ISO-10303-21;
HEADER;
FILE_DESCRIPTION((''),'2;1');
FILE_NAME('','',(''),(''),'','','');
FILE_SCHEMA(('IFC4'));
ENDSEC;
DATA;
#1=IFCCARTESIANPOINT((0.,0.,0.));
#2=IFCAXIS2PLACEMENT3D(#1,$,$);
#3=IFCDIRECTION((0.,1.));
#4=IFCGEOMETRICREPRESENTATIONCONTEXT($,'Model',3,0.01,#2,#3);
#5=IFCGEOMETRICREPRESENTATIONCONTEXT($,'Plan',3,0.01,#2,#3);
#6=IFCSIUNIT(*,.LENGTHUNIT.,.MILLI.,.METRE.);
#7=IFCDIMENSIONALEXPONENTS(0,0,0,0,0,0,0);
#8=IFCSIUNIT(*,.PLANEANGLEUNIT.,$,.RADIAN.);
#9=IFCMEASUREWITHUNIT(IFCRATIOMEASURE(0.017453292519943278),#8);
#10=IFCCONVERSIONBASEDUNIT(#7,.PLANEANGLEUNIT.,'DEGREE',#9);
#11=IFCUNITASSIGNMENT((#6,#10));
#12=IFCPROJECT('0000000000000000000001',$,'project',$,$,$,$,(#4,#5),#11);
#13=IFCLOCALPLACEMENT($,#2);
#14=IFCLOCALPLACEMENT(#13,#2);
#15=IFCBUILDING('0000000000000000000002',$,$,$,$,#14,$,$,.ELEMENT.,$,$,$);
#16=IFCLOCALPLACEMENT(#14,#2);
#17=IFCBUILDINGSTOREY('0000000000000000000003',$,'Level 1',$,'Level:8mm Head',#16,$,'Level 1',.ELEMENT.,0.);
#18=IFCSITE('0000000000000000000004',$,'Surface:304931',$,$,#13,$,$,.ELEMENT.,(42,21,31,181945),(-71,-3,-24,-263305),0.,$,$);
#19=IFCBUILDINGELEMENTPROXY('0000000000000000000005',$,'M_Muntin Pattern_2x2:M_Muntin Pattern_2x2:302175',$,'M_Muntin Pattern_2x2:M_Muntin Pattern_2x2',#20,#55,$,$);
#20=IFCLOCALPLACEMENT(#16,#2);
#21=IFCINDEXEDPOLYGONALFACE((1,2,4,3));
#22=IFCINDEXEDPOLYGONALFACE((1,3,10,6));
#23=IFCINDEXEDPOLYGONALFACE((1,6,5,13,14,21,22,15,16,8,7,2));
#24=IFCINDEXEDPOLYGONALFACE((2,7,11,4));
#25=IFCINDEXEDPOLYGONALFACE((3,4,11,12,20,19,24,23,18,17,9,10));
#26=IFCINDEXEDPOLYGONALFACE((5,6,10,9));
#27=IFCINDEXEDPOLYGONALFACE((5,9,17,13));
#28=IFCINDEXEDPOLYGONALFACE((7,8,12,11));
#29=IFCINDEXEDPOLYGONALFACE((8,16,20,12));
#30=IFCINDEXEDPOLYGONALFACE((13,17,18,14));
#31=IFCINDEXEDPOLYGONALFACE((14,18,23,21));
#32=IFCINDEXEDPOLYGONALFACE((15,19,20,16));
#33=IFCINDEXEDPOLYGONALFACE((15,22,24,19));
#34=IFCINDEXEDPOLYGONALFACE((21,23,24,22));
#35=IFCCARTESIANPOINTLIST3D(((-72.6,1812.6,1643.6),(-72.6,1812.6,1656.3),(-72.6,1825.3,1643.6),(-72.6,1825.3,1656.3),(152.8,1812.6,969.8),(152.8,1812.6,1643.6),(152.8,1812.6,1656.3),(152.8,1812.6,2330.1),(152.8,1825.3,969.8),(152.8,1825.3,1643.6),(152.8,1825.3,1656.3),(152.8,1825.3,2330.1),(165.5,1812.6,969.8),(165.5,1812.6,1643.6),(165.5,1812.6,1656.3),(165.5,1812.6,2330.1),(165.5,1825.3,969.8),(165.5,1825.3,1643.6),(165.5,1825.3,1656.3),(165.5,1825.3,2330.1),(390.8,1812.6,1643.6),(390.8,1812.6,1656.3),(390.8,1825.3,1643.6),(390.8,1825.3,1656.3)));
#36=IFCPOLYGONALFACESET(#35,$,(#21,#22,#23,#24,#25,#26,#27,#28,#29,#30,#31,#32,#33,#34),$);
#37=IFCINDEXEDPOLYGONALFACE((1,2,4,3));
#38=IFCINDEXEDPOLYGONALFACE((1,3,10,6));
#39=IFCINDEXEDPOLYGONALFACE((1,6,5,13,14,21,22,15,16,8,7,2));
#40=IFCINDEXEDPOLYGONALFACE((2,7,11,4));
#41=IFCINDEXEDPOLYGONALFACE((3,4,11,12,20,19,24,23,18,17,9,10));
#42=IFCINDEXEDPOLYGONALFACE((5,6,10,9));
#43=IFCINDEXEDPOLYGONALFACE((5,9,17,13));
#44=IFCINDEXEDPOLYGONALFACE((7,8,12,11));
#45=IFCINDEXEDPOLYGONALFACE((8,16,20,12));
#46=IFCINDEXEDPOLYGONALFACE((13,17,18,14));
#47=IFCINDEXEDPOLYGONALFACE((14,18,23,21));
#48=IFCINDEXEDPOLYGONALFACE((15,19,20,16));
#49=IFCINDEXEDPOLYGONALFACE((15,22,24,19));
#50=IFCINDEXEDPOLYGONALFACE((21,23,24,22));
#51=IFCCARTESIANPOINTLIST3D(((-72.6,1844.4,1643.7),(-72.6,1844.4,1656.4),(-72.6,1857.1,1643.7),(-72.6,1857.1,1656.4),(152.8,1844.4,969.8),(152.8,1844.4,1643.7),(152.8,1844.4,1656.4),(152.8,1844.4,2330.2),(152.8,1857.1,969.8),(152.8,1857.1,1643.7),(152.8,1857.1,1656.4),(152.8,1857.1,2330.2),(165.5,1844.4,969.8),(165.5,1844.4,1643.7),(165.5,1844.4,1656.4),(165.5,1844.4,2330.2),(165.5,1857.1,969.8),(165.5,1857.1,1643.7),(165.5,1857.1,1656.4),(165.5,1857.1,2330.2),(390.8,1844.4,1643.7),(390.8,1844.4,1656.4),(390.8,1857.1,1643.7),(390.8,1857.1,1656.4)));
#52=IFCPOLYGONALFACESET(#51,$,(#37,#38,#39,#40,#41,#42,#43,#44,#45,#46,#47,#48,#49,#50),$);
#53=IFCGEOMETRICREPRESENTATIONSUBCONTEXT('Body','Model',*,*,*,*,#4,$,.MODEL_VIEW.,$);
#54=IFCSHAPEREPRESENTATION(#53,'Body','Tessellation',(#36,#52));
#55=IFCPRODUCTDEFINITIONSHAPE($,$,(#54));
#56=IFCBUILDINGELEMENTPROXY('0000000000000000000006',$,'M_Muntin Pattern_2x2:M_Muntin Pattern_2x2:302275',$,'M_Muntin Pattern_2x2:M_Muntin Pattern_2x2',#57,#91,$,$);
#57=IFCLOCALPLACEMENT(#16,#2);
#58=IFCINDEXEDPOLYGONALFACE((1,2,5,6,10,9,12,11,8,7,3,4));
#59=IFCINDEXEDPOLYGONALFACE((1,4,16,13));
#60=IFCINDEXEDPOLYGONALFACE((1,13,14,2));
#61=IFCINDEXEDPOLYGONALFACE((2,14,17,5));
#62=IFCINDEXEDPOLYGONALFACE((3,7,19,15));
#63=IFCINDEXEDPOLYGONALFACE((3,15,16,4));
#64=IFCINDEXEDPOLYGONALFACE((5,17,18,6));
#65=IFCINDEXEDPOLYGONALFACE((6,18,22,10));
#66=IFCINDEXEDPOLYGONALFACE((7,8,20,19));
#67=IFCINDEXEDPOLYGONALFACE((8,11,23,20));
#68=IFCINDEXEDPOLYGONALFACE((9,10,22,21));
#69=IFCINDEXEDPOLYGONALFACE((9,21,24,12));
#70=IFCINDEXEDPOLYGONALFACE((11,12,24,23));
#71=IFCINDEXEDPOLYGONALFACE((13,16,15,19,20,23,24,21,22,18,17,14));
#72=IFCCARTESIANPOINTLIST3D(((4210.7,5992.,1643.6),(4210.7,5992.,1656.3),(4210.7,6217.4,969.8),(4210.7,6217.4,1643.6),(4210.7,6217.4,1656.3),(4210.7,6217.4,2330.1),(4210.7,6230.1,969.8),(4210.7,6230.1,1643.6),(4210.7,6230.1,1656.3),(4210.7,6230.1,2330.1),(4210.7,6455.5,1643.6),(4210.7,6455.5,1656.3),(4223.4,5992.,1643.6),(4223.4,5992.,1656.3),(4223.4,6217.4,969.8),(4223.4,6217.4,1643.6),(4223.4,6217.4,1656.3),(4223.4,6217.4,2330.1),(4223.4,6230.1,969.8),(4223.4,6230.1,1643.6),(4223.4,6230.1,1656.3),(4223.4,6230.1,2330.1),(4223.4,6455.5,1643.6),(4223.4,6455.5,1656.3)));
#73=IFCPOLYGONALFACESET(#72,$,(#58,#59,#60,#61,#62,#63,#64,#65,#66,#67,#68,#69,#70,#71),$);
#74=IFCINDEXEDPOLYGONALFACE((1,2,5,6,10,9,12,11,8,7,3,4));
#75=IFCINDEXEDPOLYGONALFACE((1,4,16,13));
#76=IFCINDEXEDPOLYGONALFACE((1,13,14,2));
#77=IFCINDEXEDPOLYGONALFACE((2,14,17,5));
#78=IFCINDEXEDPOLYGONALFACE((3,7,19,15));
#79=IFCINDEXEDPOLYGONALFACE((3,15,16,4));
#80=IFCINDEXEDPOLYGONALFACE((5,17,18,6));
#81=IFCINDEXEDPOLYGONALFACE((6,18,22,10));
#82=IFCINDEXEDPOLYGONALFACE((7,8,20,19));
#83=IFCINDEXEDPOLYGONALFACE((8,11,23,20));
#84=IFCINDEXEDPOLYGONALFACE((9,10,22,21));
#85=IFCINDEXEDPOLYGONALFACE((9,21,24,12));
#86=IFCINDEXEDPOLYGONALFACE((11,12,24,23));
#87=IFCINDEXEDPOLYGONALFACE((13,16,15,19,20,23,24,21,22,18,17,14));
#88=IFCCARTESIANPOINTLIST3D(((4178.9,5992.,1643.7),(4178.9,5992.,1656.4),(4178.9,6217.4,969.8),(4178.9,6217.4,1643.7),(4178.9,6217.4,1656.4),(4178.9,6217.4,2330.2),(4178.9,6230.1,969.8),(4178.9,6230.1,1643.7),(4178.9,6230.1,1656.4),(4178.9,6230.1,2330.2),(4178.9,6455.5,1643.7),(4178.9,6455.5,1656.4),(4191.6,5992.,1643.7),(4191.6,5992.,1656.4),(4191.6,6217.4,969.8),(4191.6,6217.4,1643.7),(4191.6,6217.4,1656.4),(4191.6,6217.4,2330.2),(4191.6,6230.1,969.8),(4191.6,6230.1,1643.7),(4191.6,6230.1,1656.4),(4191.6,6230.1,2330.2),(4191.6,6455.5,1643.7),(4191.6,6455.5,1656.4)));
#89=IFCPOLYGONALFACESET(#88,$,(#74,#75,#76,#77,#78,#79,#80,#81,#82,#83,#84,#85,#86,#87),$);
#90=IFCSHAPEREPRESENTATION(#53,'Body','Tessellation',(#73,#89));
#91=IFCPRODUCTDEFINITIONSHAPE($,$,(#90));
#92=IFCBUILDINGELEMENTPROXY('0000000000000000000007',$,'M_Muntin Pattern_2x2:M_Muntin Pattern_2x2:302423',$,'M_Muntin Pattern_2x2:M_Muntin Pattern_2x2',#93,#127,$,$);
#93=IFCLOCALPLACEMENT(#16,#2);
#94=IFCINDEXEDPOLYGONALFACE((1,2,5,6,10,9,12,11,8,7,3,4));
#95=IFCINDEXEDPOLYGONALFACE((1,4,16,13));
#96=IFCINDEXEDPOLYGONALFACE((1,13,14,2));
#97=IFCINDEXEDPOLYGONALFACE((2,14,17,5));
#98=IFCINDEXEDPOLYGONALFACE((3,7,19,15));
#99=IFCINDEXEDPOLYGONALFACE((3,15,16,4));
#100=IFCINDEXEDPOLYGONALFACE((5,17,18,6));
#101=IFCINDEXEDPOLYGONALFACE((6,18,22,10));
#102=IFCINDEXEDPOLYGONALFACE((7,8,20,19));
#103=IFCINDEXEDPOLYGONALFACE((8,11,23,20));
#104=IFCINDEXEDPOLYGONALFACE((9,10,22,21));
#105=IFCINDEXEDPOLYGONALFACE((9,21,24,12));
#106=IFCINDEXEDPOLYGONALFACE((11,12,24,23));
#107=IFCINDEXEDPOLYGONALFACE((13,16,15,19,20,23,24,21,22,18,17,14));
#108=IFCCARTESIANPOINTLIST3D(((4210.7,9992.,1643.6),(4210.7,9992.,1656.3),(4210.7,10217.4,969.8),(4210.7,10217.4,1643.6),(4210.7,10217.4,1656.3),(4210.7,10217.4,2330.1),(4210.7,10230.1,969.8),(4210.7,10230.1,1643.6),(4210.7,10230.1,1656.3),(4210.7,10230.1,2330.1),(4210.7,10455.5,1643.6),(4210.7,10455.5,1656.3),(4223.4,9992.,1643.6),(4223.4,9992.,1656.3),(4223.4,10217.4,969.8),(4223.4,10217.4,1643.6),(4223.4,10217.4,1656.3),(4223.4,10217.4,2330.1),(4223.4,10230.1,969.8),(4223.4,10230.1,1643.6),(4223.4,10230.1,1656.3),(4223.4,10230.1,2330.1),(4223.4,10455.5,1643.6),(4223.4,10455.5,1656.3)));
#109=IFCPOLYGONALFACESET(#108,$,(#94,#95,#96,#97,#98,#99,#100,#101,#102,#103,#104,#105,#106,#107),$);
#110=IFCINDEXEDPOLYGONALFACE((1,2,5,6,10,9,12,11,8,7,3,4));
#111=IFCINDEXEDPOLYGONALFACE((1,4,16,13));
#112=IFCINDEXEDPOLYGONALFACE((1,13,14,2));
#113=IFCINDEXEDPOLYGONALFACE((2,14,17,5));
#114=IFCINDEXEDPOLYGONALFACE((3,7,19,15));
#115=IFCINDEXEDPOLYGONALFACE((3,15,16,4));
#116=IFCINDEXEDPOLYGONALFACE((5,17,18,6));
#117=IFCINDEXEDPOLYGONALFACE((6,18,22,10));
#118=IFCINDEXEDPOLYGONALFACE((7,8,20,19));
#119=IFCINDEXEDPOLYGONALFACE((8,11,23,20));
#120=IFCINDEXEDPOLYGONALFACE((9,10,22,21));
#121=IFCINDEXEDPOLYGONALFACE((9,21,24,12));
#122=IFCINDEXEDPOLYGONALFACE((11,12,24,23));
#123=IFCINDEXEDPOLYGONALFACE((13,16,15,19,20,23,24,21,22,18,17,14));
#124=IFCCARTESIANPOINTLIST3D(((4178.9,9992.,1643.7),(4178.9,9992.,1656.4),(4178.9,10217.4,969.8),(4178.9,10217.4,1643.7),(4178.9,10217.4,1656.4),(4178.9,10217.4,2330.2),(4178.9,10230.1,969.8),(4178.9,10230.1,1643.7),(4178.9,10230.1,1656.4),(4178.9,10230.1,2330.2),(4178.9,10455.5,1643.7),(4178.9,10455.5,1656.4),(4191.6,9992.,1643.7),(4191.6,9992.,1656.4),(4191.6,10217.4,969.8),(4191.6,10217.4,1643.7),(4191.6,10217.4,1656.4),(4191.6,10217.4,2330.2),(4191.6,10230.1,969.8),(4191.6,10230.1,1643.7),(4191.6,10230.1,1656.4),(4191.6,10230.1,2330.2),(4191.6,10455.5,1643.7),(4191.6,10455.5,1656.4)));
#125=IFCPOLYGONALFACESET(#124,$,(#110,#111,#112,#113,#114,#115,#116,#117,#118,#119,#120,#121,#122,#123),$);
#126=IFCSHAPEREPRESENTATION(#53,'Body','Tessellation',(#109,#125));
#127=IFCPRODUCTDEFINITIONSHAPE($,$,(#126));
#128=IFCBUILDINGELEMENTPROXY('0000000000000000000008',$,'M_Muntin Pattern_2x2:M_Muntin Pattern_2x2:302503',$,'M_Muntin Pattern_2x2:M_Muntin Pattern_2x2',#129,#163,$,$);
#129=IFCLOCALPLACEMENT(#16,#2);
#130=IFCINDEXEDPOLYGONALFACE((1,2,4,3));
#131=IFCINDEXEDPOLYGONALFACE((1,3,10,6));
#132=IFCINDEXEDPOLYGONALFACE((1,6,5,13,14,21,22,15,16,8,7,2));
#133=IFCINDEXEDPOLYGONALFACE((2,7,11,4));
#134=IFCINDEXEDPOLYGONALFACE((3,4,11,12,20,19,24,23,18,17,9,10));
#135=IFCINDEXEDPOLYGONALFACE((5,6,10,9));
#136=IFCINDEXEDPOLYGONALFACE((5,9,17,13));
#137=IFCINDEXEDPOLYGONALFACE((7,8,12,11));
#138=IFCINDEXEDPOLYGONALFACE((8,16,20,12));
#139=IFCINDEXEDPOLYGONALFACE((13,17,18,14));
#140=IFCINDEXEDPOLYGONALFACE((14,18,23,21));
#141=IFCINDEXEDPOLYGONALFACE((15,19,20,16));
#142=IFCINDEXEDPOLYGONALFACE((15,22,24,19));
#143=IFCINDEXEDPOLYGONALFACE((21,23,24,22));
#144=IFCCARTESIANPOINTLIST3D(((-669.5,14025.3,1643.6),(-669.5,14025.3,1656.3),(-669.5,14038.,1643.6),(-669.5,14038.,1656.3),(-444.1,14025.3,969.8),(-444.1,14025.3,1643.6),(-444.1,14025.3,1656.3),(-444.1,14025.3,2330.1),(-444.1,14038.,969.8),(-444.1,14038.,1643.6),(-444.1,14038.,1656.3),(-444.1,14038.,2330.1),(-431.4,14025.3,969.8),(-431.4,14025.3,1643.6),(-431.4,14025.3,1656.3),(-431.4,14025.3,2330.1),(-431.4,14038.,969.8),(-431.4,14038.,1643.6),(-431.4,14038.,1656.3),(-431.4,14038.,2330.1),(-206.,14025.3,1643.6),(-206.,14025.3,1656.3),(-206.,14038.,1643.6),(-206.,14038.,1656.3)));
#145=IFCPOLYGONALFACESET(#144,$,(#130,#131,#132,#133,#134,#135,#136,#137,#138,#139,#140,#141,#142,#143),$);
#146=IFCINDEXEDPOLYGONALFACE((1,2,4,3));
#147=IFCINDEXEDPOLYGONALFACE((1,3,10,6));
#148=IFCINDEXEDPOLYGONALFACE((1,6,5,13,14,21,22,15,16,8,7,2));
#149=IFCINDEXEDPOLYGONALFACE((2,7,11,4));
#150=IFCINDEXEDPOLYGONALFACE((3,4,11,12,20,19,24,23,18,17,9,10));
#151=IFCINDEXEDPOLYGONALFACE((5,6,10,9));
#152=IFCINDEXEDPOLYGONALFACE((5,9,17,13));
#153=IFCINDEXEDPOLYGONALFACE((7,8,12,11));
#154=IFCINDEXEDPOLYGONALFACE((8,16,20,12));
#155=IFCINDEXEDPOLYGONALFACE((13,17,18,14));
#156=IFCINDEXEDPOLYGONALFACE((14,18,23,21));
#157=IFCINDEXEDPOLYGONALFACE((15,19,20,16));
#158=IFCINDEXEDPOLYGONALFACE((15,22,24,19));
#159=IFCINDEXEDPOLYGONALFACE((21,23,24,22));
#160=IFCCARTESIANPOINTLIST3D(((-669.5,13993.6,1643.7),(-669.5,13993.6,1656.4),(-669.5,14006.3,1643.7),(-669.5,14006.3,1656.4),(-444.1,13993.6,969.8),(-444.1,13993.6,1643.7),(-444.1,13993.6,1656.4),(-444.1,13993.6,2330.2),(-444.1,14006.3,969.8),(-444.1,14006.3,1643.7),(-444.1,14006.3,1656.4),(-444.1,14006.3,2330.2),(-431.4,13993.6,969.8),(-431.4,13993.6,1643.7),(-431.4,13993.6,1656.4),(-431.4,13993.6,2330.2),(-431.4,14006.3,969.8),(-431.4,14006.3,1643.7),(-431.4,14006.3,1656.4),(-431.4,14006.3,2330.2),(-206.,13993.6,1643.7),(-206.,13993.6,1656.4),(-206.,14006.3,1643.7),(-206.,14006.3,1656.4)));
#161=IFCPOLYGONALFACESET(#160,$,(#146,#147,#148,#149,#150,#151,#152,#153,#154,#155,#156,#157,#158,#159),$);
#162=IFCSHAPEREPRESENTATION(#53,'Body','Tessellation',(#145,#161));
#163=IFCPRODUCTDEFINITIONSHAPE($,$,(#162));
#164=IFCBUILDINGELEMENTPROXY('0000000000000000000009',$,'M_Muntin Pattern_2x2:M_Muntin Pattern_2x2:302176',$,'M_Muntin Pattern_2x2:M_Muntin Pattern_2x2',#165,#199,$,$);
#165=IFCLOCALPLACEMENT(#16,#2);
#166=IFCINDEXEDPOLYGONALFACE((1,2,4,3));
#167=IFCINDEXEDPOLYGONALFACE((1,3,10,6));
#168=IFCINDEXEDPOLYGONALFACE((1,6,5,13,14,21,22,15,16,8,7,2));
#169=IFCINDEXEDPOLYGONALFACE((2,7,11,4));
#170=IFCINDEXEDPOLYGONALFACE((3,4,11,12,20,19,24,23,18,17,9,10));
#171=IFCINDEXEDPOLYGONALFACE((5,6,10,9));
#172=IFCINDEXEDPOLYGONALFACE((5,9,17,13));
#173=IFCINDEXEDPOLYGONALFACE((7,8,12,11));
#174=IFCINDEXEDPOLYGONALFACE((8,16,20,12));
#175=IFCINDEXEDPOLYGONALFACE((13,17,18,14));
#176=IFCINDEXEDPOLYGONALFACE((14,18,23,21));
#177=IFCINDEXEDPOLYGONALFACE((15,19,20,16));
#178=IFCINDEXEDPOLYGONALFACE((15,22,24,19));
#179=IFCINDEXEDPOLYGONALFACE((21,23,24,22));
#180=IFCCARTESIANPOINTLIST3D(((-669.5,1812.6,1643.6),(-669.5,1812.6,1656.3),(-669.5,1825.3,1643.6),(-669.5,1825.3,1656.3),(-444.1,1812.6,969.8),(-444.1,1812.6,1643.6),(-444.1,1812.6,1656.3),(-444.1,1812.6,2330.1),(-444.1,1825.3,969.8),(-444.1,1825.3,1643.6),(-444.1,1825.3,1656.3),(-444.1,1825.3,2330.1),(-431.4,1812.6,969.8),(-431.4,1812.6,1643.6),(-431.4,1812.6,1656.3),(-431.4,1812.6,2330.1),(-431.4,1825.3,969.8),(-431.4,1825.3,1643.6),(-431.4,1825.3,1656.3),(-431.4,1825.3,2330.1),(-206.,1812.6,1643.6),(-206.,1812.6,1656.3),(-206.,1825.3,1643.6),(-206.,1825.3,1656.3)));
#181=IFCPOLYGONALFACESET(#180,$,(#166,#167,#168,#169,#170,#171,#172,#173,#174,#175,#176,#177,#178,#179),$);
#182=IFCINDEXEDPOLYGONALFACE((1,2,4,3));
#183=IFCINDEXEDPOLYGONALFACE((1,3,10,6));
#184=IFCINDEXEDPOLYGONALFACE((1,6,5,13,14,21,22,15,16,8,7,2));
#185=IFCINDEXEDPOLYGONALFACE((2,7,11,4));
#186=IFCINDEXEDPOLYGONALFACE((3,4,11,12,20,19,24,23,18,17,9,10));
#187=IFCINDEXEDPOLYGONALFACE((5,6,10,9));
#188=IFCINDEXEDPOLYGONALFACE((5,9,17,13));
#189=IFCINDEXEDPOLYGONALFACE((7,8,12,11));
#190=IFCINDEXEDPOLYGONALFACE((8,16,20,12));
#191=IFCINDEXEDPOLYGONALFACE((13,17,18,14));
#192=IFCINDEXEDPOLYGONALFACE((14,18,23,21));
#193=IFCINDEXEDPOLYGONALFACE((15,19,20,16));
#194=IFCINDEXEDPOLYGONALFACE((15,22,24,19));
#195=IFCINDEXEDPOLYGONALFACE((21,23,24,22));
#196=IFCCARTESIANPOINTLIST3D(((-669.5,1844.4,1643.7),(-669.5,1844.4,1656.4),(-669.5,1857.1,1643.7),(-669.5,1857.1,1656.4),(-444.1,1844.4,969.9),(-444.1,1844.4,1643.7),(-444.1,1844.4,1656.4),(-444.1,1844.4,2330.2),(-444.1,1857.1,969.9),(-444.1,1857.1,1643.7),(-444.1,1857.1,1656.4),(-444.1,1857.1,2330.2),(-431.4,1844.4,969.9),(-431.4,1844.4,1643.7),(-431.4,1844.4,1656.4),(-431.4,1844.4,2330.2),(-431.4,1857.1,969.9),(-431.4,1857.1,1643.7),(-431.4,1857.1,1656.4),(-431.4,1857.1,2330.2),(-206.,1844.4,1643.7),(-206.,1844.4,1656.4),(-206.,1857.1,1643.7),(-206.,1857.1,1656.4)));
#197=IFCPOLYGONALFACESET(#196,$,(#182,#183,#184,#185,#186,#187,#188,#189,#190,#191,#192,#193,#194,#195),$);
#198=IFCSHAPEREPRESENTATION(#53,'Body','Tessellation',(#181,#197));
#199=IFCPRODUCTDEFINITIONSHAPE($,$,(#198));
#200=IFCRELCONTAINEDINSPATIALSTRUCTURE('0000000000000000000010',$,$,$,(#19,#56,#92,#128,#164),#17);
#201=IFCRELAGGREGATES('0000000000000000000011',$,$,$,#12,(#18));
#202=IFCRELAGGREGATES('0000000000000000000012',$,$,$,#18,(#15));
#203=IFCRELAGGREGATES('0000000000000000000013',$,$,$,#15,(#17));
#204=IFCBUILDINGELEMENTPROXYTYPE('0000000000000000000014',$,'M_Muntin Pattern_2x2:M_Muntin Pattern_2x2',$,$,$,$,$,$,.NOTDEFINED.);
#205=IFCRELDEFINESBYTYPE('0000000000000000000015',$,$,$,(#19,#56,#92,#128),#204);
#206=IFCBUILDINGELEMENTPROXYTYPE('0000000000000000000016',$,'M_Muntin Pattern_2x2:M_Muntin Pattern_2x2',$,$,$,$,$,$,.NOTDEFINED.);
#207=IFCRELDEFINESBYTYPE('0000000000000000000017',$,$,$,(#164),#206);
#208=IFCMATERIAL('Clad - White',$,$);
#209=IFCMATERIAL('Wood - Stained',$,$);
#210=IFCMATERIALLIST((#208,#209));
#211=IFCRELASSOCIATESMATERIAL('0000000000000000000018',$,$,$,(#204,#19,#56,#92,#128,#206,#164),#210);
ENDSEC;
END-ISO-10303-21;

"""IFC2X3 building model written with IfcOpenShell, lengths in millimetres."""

from ifc_helpers import new_model, entity, si_unit, converted_unit, direction, frame, origin, place, context, subcontext, project, spatial, polyline, outline, extrude, source, transform, mapped, material, material_list, type_object, type_shapes, element, save


model = new_model("IFC2X3")

# Units and contexts
model_context = context("Model", 3, precision=0.01, world=origin(), true_north=direction((0.0, 1.0)))
plan_context = context("Plan", 3, precision=0.01, world=origin(), true_north=direction((0.0, 1.0)))
body_context = subcontext(model_context, "Body", "Model", "MODEL_VIEW")
ifc_project = project(units=[si_unit("LENGTHUNIT", "METRE", prefix="MILLI"), converted_unit("PLANEANGLEUNIT", "DEGREE", entity("IfcRatioMeasure", 0.017453292519943278), si_unit("PLANEANGLEUNIT", "RADIAN"), dimensions=[0, 0, 0, 0, 0, 0, 0])], contexts=[model_context, plan_context])

# Site, building, storey
site_placement = place(None, origin())
site = spatial("IfcSite", under=ifc_project, at=site_placement, Name="Surface:304931", CompositionType="ELEMENT", RefLatitude=(42, 21, 31, 181945), RefLongitude=(-71, -3, -24, -263305), RefElevation=0.0)
building_placement = place(site_placement, origin())
building = spatial("IfcBuilding", under=site, at=building_placement, CompositionType="ELEMENT")
storey_placement = place(building_placement, origin())
storey = spatial("IfcBuildingStorey", under=building, at=storey_placement, Name="Level 1", ObjectType="Level:8mm Head", LongName="Level 1", CompositionType="ELEMENT", Elevation=0.0)

# Building element proxies
ifc_material_1 = material(Name="Clad - White")
ifc_material_2 = material(Name="Wood - Stained")
ifc_material_list_1 = material_list([ifc_material_1, ifc_material_2])
building_element_proxy_type_1 = type_object("IfcBuildingElementProxyType", Name="M_Muntin Pattern_2x2:M_Muntin Pattern_2x2", PredefinedType="NOTDEFINED", material=ifc_material_list_1)
shared_shape_1 = source(origin(), body_context, "Body", "SweptSolid", [
    extrude(outline(polyline([(6.4, -6.4), (680.1, -6.4), (680.1, 6.3), (6.4, 6.3), (6.4, 231.7), (-6.3, 231.7), (-6.3, 6.3), (-680.2, 6.3), (-680.2, -6.4), (-6.3, -6.4), (-6.3, -231.7), (6.4, -231.7), (6.4, -6.4)])), frame((0.0, 9.5, 680.1), z_axis=(0.0, 1.0, 0.0), x_axis=(0.0, 0.0, 1.0)), (0.0, 0.0, 1.0), 12.7),
    extrude(outline(polyline([(6.4, -6.4), (680.2, -6.4), (680.2, 6.3), (6.4, 6.3), (6.4, 231.7), (-6.3, 231.7), (-6.3, 6.3), (-680.2, 6.3), (-680.2, -6.4), (-6.3, -6.4), (-6.3, -231.7), (6.4, -231.7), (6.4, -6.4)])), frame((0.0, -22.2, 680.2), z_axis=(0.0, 1.0, 0.0), x_axis=(0.0, 0.0, 1.0)), (0.0, 0.0, 1.0), 12.7),
])
type_shapes(building_element_proxy_type_1, [shared_shape_1])
for number, where, z_axis, x_axis, name in (
    (1, (159.1, 1834.8, 969.8), (0.0, 0.0, 1.0), (-1.0, 0.0, 0.0), "M_Muntin Pattern_2x2:M_Muntin Pattern_2x2:302175"),
    (2, (4201.2, 6223.7, 969.8), (0.0, 0.0, 1.0), (0.0, -1.0, 0.0), "M_Muntin Pattern_2x2:M_Muntin Pattern_2x2:302275"),
    (3, (4201.2, 10223.7, 969.8), (0.0, 0.0, 1.0), (0.0, -1.0, 0.0), "M_Muntin Pattern_2x2:M_Muntin Pattern_2x2:302423"),
):
    element("IfcBuildingElementProxy", number, at=place(storey_placement, frame(where, z_axis=z_axis, x_axis=x_axis)), inside=storey, type_object=building_element_proxy_type_1, material=ifc_material_list_1, Name=name, ObjectType="M_Muntin Pattern_2x2:M_Muntin Pattern_2x2", context=body_context, shape_type="MappedRepresentation", body=[
        mapped(shared_shape_1, transform((0.0, 0.0, 0.0), scale=1.0)),
    ])
proxy_1_placement = place(storey_placement, frame((-437.7, 14015.8, 969.8)))
element("IfcBuildingElementProxy", 4, at=proxy_1_placement, inside=storey, type_object=building_element_proxy_type_1, material=ifc_material_list_1, Name="M_Muntin Pattern_2x2:M_Muntin Pattern_2x2:302503", ObjectType="M_Muntin Pattern_2x2:M_Muntin Pattern_2x2", context=body_context, shape_type="MappedRepresentation", body=[
    mapped(shared_shape_1, transform((0.0, 0.0, 0.0), scale=1.0)),
])
building_element_proxy_type_2 = type_object("IfcBuildingElementProxyType", Name="M_Muntin Pattern_2x2:M_Muntin Pattern_2x2", PredefinedType="NOTDEFINED", material=ifc_material_list_1)
shared_shape_2 = source(origin(), body_context, "Body", "SweptSolid", [
    extrude(outline(polyline([(6.4, -6.4), (680.1, -6.4), (680.1, 6.3), (6.4, 6.3), (6.4, 231.7), (-6.3, 231.7), (-6.3, 6.3), (-680.2, 6.3), (-680.2, -6.4), (-6.3, -6.4), (-6.3, -231.7), (6.4, -231.7), (6.4, -6.4)])), frame((0.0, -22.2, 680.1), z_axis=(0.0, 1.0, 0.0), x_axis=(0.0, 0.0, 1.0)), (0.0, 0.0, 1.0), 12.7),
    extrude(outline(polyline([(6.4, -6.4), (680.2, -6.4), (680.2, 6.3), (6.4, 6.3), (6.4, 231.7), (-6.3, 231.7), (-6.3, 6.3), (-680.2, 6.3), (-680.2, -6.4), (-6.3, -6.4), (-6.3, -231.7), (6.4, -231.7), (6.4, -6.4)])), frame((0.0, 9.5, 680.2), z_axis=(0.0, 1.0, 0.0), x_axis=(0.0, 0.0, 1.0)), (0.0, 0.0, 1.0), 12.7),
])
type_shapes(building_element_proxy_type_2, [shared_shape_2])
proxy_2_placement = place(storey_placement, frame((-437.7, 1834.8, 969.9)))
element("IfcBuildingElementProxy", 5, at=proxy_2_placement, inside=storey, type_object=building_element_proxy_type_2, material=ifc_material_list_1, Name="M_Muntin Pattern_2x2:M_Muntin Pattern_2x2:302176", ObjectType="M_Muntin Pattern_2x2:M_Muntin Pattern_2x2", context=body_context, shape_type="MappedRepresentation", body=[
    mapped(shared_shape_2, transform((0.0, 0.0, 0.0), scale=1.0)),
])

save(model, "model.ifc")
